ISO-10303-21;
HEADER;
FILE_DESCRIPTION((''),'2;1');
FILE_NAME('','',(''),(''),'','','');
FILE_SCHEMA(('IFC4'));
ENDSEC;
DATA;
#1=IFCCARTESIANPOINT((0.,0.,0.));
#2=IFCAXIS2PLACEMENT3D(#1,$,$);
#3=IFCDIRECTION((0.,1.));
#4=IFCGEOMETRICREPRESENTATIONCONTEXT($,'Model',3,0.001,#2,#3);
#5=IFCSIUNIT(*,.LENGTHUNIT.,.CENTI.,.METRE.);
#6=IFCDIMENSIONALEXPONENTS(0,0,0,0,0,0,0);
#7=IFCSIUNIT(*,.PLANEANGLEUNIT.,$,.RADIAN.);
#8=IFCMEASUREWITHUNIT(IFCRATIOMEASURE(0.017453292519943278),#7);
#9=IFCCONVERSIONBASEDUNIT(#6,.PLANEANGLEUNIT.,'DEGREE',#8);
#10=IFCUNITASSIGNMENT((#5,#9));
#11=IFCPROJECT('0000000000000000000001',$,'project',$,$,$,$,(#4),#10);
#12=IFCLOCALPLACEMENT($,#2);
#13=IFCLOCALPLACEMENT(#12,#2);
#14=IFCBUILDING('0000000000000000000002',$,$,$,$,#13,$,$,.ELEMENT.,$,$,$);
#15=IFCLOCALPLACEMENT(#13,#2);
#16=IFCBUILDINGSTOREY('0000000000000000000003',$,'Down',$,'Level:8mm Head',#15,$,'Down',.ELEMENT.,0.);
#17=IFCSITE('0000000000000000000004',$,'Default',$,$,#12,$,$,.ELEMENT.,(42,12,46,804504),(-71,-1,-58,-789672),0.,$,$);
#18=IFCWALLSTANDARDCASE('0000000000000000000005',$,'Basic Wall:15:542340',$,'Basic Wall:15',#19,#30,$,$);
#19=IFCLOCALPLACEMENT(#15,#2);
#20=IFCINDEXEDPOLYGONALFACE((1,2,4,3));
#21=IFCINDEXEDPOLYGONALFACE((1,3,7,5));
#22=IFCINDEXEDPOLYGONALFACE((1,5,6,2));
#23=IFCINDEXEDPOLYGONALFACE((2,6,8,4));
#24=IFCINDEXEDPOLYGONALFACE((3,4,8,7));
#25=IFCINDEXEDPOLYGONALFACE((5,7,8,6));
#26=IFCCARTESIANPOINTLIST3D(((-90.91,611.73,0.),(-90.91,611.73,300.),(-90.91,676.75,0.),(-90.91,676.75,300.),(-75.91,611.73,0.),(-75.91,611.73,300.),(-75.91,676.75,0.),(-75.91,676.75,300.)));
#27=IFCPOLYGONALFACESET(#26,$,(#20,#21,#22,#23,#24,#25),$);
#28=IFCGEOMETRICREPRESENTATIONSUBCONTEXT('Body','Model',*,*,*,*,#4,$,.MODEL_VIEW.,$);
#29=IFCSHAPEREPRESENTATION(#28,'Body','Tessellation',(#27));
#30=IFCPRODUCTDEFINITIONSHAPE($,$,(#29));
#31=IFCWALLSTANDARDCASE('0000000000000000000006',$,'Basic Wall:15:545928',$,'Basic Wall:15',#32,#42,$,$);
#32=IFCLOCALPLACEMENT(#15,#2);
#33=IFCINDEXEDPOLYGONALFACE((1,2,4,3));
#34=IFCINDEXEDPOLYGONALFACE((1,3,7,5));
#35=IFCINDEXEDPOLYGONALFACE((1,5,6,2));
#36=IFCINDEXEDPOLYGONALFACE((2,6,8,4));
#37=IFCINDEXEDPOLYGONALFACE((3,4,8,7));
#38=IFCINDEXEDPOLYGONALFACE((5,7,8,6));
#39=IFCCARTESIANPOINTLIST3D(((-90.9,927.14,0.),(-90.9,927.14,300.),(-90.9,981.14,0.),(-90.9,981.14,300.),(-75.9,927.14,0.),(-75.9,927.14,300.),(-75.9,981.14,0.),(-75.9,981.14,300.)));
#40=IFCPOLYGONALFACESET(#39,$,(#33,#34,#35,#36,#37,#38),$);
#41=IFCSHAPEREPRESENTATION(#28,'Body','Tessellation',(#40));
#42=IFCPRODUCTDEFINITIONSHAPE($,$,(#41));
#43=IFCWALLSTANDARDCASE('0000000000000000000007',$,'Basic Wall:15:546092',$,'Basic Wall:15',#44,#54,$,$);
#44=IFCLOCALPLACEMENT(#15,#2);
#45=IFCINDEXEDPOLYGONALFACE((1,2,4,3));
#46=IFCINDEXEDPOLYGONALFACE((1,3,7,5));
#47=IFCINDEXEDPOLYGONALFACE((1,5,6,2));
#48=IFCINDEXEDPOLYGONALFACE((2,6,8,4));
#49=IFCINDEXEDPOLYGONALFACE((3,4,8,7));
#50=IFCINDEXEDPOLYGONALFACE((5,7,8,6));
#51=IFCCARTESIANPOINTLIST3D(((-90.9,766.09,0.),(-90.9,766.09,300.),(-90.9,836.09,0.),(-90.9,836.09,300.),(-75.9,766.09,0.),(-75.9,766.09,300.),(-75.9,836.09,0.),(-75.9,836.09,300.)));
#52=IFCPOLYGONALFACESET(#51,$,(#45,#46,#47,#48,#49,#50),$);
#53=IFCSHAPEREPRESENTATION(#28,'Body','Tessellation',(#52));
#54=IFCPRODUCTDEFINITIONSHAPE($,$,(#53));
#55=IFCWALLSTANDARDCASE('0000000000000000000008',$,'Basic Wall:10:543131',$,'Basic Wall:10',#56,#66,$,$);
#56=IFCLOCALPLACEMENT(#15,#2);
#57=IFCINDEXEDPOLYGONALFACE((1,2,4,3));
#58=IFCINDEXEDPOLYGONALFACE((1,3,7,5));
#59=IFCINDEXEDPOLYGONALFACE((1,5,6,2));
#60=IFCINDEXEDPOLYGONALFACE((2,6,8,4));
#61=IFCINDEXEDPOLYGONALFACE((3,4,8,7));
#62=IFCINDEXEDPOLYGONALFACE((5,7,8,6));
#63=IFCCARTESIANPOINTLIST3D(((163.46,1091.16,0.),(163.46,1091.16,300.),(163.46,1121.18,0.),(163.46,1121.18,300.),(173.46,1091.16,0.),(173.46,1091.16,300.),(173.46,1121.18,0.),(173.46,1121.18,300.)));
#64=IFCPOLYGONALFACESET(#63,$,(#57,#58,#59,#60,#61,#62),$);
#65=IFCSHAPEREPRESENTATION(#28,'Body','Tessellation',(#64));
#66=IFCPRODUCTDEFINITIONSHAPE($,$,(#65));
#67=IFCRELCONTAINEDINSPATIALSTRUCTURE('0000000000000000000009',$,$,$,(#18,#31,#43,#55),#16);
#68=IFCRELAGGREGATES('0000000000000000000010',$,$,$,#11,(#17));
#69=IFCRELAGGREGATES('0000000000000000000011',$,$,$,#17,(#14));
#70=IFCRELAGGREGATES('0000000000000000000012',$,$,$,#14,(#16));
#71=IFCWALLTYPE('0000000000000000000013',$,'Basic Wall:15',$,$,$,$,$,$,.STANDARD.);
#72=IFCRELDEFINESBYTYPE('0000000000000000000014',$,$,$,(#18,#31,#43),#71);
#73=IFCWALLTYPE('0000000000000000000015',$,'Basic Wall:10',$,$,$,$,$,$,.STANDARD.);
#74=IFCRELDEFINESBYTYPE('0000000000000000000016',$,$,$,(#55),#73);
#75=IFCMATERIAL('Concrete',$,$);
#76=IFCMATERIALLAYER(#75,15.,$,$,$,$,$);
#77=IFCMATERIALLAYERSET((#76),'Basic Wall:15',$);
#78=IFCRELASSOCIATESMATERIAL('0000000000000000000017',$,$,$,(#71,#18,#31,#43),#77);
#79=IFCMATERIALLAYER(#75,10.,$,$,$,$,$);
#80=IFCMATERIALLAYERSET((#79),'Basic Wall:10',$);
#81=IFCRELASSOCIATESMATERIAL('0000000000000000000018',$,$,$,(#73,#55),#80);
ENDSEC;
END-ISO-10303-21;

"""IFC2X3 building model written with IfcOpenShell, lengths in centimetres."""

from ifc_helpers import new_model, entity, si_unit, converted_unit, direction, frame, frame_2d, origin, place, context, subcontext, project, spatial, rectangle, extrude, material, layer, layer_set, layer_usage, type_object, element, save


model = new_model("IFC2X3")

# Units and contexts
model_context = context("Model", 3, precision=0.001, world=origin(), true_north=direction((0.0, 1.0)))
body_context = subcontext(model_context, "Body", "Model", "MODEL_VIEW")
ifc_project = project(units=[si_unit("LENGTHUNIT", "METRE", prefix="CENTI"), converted_unit("PLANEANGLEUNIT", "DEGREE", entity("IfcRatioMeasure", 0.017453292519943278), si_unit("PLANEANGLEUNIT", "RADIAN"), dimensions=[0, 0, 0, 0, 0, 0, 0])], contexts=[model_context])

# Site, building, storey
site_placement = place(None, origin())
site = spatial("IfcSite", under=ifc_project, at=site_placement, Name="Default", CompositionType="ELEMENT", RefLatitude=(42, 12, 46, 804504), RefLongitude=(-71, -1, -58, -789672), RefElevation=0.0)
building_placement = place(site_placement, origin())
building = spatial("IfcBuilding", under=site, at=building_placement, CompositionType="ELEMENT")
storey_placement = place(building_placement, origin())
storey = spatial("IfcBuildingStorey", under=building, at=storey_placement, Name="Down", ObjectType="Level:8mm Head", LongName="Down", CompositionType="ELEMENT", Elevation=0.0)

# Walls
ifc_material = material(Name="Concrete")
ifc_layer_1 = layer(ifc_material, 15.0)
ifc_layer_set_1 = layer_set([ifc_layer_1], Name="Basic Wall:15")
ifc_layer_usage_1 = layer_usage(ifc_layer_set_1, "AXIS2", "POSITIVE", -7.5)
wall_type_1 = type_object("IfcWallType", Name="Basic Wall:15", PredefinedType="STANDARD", material=ifc_layer_set_1)
wall_1_placement = place(storey_placement, frame((-83.41, 611.73, 0.0), z_axis=(0.0, 0.0, 1.0), x_axis=(0.0, 1.0, 0.0)))
element("IfcWallStandardCase", 1, at=wall_1_placement, inside=storey, type_object=wall_type_1, material=ifc_layer_usage_1, Name="Basic Wall:15:542340", ObjectType="Basic Wall:15", context=body_context, shape_type="SweptSolid", body=[
    extrude(rectangle(XDim=65.02, YDim=15.0, at=frame_2d((32.51, 0.0), x_axis=(-1.0, 0.0))), origin(), (0.0, 0.0, 1.0), 300.0),
])
ifc_layer_usage_2 = layer_usage(ifc_layer_set_1, "AXIS2", "NEGATIVE", 7.5)
wall_2_placement = place(storey_placement, frame((-83.4, 981.14, 0.0), z_axis=(0.0, 0.0, 1.0), x_axis=(0.0, -1.0, 0.0)))
element("IfcWallStandardCase", 2, at=wall_2_placement, inside=storey, type_object=wall_type_1, material=ifc_layer_usage_2, Name="Basic Wall:15:545928", ObjectType="Basic Wall:15", context=body_context, shape_type="SweptSolid", body=[
    extrude(rectangle(XDim=54.01, YDim=15.0, at=frame_2d((27.0, 0.0), x_axis=(-1.0, 0.0))), origin(), (0.0, 0.0, 1.0), 300.0),
])
ifc_layer_usage_3 = layer_usage(ifc_layer_set_1, "AXIS2", "NEGATIVE", 7.5)
wall_3_placement = place(storey_placement, frame((-83.4, 836.09, 0.0), z_axis=(0.0, 0.0, 1.0), x_axis=(0.0, -1.0, 0.0)))
element("IfcWallStandardCase", 3, at=wall_3_placement, inside=storey, type_object=wall_type_1, material=ifc_layer_usage_3, Name="Basic Wall:15:546092", ObjectType="Basic Wall:15", context=body_context, shape_type="SweptSolid", body=[
    extrude(rectangle(XDim=70.0, YDim=15.0, at=frame_2d((35.0, 0.0), x_axis=(-1.0, 0.0))), origin(), (0.0, 0.0, 1.0), 300.0),
])
ifc_layer_2 = layer(ifc_material, 10.0)
ifc_layer_set_2 = layer_set([ifc_layer_2], Name="Basic Wall:10")
ifc_layer_usage_4 = layer_usage(ifc_layer_set_2, "AXIS2", "NEGATIVE", 5.0)
wall_type_2 = type_object("IfcWallType", Name="Basic Wall:10", PredefinedType="STANDARD", material=ifc_layer_set_2)
wall_4_placement = place(storey_placement, frame((168.46, 1091.16, 0.0), z_axis=(0.0, 0.0, 1.0), x_axis=(0.0, 1.0, 0.0)))
element("IfcWallStandardCase", 4, at=wall_4_placement, inside=storey, type_object=wall_type_2, material=ifc_layer_usage_4, Name="Basic Wall:10:543131", ObjectType="Basic Wall:10", context=body_context, shape_type="SweptSolid", body=[
    extrude(rectangle(XDim=30.03, YDim=10.0, at=frame_2d((15.01, 0.0), x_axis=(-1.0, 0.0))), origin(), (0.0, 0.0, 1.0), 300.0),
])

save(model, "model.ifc")
